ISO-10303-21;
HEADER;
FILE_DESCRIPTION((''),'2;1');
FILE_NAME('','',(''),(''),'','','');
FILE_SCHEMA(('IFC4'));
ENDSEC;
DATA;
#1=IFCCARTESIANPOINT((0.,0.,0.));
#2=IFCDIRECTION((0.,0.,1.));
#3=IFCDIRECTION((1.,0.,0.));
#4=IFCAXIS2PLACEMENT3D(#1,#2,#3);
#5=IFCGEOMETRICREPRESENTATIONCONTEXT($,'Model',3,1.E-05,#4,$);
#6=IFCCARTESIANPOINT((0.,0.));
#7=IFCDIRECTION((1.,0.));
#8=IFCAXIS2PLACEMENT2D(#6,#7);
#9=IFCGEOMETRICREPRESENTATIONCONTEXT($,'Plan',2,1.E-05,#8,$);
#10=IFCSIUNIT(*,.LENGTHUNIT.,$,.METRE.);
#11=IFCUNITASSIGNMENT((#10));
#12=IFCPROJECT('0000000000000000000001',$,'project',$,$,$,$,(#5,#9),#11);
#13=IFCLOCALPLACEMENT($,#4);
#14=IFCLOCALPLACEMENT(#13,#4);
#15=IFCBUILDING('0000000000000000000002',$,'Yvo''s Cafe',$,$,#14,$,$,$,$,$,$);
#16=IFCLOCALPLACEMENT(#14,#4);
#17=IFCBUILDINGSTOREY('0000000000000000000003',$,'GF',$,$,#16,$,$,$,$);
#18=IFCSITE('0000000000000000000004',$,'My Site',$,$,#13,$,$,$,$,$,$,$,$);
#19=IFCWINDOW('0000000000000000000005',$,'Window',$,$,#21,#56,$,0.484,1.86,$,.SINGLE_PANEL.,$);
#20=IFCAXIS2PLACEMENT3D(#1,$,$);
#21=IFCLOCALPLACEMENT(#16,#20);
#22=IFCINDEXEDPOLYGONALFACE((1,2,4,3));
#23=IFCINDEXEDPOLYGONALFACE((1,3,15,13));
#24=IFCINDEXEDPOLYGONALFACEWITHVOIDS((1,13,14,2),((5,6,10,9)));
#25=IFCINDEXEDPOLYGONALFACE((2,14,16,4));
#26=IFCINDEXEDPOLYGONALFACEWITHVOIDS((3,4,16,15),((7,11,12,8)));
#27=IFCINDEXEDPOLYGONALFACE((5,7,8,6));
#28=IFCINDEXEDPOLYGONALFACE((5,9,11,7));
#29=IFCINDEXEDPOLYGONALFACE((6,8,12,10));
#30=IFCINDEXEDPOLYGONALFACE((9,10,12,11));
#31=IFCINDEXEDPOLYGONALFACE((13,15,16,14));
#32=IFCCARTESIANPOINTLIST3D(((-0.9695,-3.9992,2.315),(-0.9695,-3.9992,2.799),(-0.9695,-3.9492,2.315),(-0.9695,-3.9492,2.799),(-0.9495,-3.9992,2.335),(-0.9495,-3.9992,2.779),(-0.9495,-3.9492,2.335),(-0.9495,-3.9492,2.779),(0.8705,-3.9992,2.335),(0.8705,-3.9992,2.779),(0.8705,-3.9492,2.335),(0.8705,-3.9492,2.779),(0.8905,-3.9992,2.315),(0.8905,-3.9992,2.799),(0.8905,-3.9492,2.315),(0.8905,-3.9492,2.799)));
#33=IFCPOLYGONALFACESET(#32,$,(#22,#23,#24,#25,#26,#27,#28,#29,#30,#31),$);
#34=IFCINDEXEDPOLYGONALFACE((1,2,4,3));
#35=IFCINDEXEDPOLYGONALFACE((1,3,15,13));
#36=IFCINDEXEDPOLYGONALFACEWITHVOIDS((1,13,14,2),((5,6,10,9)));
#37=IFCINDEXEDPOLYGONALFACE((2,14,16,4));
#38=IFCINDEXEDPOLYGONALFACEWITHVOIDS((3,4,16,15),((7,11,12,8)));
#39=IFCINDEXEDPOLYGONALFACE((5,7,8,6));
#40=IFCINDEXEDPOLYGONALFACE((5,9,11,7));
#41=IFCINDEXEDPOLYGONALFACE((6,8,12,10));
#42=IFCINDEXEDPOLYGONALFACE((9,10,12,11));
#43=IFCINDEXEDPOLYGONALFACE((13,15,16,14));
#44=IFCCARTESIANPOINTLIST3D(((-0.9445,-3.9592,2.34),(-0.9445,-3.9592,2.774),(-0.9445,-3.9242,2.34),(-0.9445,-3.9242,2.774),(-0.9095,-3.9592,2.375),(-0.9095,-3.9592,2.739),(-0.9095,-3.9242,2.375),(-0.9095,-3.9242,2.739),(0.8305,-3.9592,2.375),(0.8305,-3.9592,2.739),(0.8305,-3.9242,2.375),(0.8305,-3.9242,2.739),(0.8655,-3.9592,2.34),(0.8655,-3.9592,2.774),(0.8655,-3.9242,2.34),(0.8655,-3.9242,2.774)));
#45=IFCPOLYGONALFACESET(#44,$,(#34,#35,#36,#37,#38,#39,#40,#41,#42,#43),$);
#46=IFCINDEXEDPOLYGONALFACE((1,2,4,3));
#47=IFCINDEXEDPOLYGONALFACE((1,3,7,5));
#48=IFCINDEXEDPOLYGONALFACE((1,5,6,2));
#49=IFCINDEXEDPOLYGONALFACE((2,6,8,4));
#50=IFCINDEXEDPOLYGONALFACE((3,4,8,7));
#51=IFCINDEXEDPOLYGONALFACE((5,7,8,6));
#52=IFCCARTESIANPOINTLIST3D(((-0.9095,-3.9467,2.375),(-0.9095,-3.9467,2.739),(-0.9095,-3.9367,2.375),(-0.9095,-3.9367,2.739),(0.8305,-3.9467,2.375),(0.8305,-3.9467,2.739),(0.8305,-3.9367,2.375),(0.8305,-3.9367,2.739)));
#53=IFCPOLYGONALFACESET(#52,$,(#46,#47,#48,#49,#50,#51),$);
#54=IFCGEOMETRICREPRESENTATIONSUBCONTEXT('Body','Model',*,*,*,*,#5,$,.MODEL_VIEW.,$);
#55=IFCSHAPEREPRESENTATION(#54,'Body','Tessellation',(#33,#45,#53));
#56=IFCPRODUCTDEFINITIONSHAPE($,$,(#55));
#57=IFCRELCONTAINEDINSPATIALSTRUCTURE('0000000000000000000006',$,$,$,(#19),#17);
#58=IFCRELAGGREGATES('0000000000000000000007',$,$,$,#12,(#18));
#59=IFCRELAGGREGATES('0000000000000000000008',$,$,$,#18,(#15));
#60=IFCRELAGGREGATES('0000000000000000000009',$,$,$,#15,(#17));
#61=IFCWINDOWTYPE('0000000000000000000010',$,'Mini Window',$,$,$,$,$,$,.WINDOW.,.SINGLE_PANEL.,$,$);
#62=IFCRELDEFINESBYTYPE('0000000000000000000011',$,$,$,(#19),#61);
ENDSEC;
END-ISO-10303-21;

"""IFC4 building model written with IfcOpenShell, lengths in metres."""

from ifc_helpers import new_model, entity, si_unit, frame, origin_with_axes, origin_2d_with_axis, place, context, subcontext, project, spatial, line, indexed_curve, outline, extrude, shape, source, transform, mapped, type_object, type_shapes, element, save


model = new_model("IFC4")

# Units and contexts
model_context = context("Model", 3, precision=1e-05, world=origin_with_axes())
plan_context = context("Plan", 2, precision=1e-05, world=origin_2d_with_axis())
body_context_1 = subcontext(model_context, "Body", "Model", "MODEL_VIEW")
body_context_2 = subcontext(plan_context, "Body", "Plan", "PLAN_VIEW")
ifc_project = project(units=[si_unit("LENGTHUNIT", "METRE")], contexts=[model_context, plan_context])

# Site, building, storey
site_placement = place(None, origin_with_axes())
site = spatial("IfcSite", under=ifc_project, at=site_placement, Name="My Site")
building_placement = place(site_placement, origin_with_axes())
building = spatial("IfcBuilding", under=site, at=building_placement, Name="Yvo's Cafe")
storey_placement = place(building_placement, origin_with_axes())
storey = spatial("IfcBuildingStorey", under=building, at=storey_placement, Name="GF")

# Window
window_type_1 = type_object("IfcWindowType", Name="Mini Window", PartitioningType="SINGLE_PANEL", PredefinedType="WINDOW")
shared_shape_1 = source(origin_with_axes(), body_context_1, "Body", "SweptSolid", [
    extrude(outline(indexed_curve([(0.0, 0.0), (1.86, 0.0), (1.86, 0.484), (0.0, 0.484)], segments=[line(1, 2, 3, 4, 1)]), holes=[indexed_curve([(0.02, 0.02), (1.84, 0.02), (1.84, 0.464), (0.02, 0.464)], segments=[line(1, 2, 3, 4, 1)])]), frame((0.0, 0.05, 0.0), z_axis=(0.0, -1.0, 0.0), x_axis=(1.0, 0.0, 0.0)), (0.0, 0.0, -1.0), 0.05),
    extrude(outline(indexed_curve([(0.0, 0.0), (1.81, 0.0), (1.81, 0.434), (0.0, 0.434)], segments=[line(1, 2, 3, 4, 1)]), holes=[indexed_curve([(0.035, 0.035), (1.775, 0.035), (1.775, 0.399), (0.035, 0.399)], segments=[line(1, 2, 3, 4, 1)])]), frame((0.025, 0.09, 0.025), z_axis=(0.0, -1.0, 0.0), x_axis=(1.0, 0.0, 0.0)), (0.0, 0.0, -1.0), 0.035),
    extrude(outline(indexed_curve([(0.035, 0.035), (1.775, 0.035), (1.775, 0.399), (0.035, 0.399)], segments=[line(1, 2, 3, 4, 1)])), frame((0.025, 0.1025, 0.025), z_axis=(0.0, -1.0, 0.0), x_axis=(1.0, 0.0, 0.0)), (0.0, 0.0, -1.0), 0.01),
])
shared_shape_2 = source(origin_with_axes(), body_context_2, "Body", "Curve2D", [
    entity("IfcIndexedPolyCurve", entity("IfcCartesianPointList2D", [[0.02, 0.05], [1.84, 0.05]])),
    entity("IfcIndexedPolyCurve", entity("IfcCartesianPointList2D", [[0.0, 0.1], [0.02, 0.1], [0.02, 0.05], [0.0, 0.05]]), [entity("IfcLineIndex", [1, 2, 3, 4, 1])]),
    entity("IfcIndexedPolyCurve", entity("IfcCartesianPointList2D", [[1.86, 0.1], [1.84, 0.1], [1.84, 0.05], [1.86, 0.05]]), [entity("IfcLineIndex", [1, 2, 3, 4, 1])]),
    entity("IfcIndexedPolyCurve", entity("IfcCartesianPointList2D", [[0.025, 0.09], [0.06, 0.09], [0.06, 0.125], [0.025, 0.125]]), [entity("IfcLineIndex", [1, 2, 3, 4, 1])]),
    entity("IfcIndexedPolyCurve", entity("IfcCartesianPointList2D", [[1.835, 0.09], [1.8, 0.09], [1.8, 0.125], [1.835, 0.125]]), [entity("IfcLineIndex", [1, 2, 3, 4, 1])]),
    entity("IfcIndexedPolyCurve", entity("IfcCartesianPointList2D", [[0.06, 0.09], [1.8, 0.09]])),
    entity("IfcIndexedPolyCurve", entity("IfcCartesianPointList2D", [[0.06, 0.125], [1.8, 0.125]])),
    entity("IfcIndexedPolyCurve", entity("IfcCartesianPointList2D", [[0.06, 0.1075], [1.8, 0.1075]])),
])
type_shapes(window_type_1, [shared_shape_1, shared_shape_2])
window_1_placement = place(storey_placement, frame((-0.9695, -4.0492, 2.315), z_axis=(0.0, 0.0, 1.0), x_axis=(1.0, 0.0, 0.0)))
element("IfcWindow", 1, at=window_1_placement, inside=storey, type_object=window_type_1, Name="Window", OverallHeight=0.484, OverallWidth=1.86, PartitioningType="SINGLE_PANEL", shapes=[
    shape(body_context_1, "Body", "MappedRepresentation", [mapped(shared_shape_1, transform((0.0, 0.0, 0.0), x_axis=(1.0, 0.0, 0.0), y_axis=(0.0, 1.0, 0.0), z_axis=(0.0, 0.0, 1.0), scale=1.0))]),
    shape(body_context_2, "Body", "MappedRepresentation", [mapped(shared_shape_2, transform((0.0, 0.0, 0.0), x_axis=(1.0, 0.0, 0.0), y_axis=(0.0, 1.0, 0.0), z_axis=(0.0, 0.0, 1.0), scale=1.0))]),
])

save(model, "model.ifc")
